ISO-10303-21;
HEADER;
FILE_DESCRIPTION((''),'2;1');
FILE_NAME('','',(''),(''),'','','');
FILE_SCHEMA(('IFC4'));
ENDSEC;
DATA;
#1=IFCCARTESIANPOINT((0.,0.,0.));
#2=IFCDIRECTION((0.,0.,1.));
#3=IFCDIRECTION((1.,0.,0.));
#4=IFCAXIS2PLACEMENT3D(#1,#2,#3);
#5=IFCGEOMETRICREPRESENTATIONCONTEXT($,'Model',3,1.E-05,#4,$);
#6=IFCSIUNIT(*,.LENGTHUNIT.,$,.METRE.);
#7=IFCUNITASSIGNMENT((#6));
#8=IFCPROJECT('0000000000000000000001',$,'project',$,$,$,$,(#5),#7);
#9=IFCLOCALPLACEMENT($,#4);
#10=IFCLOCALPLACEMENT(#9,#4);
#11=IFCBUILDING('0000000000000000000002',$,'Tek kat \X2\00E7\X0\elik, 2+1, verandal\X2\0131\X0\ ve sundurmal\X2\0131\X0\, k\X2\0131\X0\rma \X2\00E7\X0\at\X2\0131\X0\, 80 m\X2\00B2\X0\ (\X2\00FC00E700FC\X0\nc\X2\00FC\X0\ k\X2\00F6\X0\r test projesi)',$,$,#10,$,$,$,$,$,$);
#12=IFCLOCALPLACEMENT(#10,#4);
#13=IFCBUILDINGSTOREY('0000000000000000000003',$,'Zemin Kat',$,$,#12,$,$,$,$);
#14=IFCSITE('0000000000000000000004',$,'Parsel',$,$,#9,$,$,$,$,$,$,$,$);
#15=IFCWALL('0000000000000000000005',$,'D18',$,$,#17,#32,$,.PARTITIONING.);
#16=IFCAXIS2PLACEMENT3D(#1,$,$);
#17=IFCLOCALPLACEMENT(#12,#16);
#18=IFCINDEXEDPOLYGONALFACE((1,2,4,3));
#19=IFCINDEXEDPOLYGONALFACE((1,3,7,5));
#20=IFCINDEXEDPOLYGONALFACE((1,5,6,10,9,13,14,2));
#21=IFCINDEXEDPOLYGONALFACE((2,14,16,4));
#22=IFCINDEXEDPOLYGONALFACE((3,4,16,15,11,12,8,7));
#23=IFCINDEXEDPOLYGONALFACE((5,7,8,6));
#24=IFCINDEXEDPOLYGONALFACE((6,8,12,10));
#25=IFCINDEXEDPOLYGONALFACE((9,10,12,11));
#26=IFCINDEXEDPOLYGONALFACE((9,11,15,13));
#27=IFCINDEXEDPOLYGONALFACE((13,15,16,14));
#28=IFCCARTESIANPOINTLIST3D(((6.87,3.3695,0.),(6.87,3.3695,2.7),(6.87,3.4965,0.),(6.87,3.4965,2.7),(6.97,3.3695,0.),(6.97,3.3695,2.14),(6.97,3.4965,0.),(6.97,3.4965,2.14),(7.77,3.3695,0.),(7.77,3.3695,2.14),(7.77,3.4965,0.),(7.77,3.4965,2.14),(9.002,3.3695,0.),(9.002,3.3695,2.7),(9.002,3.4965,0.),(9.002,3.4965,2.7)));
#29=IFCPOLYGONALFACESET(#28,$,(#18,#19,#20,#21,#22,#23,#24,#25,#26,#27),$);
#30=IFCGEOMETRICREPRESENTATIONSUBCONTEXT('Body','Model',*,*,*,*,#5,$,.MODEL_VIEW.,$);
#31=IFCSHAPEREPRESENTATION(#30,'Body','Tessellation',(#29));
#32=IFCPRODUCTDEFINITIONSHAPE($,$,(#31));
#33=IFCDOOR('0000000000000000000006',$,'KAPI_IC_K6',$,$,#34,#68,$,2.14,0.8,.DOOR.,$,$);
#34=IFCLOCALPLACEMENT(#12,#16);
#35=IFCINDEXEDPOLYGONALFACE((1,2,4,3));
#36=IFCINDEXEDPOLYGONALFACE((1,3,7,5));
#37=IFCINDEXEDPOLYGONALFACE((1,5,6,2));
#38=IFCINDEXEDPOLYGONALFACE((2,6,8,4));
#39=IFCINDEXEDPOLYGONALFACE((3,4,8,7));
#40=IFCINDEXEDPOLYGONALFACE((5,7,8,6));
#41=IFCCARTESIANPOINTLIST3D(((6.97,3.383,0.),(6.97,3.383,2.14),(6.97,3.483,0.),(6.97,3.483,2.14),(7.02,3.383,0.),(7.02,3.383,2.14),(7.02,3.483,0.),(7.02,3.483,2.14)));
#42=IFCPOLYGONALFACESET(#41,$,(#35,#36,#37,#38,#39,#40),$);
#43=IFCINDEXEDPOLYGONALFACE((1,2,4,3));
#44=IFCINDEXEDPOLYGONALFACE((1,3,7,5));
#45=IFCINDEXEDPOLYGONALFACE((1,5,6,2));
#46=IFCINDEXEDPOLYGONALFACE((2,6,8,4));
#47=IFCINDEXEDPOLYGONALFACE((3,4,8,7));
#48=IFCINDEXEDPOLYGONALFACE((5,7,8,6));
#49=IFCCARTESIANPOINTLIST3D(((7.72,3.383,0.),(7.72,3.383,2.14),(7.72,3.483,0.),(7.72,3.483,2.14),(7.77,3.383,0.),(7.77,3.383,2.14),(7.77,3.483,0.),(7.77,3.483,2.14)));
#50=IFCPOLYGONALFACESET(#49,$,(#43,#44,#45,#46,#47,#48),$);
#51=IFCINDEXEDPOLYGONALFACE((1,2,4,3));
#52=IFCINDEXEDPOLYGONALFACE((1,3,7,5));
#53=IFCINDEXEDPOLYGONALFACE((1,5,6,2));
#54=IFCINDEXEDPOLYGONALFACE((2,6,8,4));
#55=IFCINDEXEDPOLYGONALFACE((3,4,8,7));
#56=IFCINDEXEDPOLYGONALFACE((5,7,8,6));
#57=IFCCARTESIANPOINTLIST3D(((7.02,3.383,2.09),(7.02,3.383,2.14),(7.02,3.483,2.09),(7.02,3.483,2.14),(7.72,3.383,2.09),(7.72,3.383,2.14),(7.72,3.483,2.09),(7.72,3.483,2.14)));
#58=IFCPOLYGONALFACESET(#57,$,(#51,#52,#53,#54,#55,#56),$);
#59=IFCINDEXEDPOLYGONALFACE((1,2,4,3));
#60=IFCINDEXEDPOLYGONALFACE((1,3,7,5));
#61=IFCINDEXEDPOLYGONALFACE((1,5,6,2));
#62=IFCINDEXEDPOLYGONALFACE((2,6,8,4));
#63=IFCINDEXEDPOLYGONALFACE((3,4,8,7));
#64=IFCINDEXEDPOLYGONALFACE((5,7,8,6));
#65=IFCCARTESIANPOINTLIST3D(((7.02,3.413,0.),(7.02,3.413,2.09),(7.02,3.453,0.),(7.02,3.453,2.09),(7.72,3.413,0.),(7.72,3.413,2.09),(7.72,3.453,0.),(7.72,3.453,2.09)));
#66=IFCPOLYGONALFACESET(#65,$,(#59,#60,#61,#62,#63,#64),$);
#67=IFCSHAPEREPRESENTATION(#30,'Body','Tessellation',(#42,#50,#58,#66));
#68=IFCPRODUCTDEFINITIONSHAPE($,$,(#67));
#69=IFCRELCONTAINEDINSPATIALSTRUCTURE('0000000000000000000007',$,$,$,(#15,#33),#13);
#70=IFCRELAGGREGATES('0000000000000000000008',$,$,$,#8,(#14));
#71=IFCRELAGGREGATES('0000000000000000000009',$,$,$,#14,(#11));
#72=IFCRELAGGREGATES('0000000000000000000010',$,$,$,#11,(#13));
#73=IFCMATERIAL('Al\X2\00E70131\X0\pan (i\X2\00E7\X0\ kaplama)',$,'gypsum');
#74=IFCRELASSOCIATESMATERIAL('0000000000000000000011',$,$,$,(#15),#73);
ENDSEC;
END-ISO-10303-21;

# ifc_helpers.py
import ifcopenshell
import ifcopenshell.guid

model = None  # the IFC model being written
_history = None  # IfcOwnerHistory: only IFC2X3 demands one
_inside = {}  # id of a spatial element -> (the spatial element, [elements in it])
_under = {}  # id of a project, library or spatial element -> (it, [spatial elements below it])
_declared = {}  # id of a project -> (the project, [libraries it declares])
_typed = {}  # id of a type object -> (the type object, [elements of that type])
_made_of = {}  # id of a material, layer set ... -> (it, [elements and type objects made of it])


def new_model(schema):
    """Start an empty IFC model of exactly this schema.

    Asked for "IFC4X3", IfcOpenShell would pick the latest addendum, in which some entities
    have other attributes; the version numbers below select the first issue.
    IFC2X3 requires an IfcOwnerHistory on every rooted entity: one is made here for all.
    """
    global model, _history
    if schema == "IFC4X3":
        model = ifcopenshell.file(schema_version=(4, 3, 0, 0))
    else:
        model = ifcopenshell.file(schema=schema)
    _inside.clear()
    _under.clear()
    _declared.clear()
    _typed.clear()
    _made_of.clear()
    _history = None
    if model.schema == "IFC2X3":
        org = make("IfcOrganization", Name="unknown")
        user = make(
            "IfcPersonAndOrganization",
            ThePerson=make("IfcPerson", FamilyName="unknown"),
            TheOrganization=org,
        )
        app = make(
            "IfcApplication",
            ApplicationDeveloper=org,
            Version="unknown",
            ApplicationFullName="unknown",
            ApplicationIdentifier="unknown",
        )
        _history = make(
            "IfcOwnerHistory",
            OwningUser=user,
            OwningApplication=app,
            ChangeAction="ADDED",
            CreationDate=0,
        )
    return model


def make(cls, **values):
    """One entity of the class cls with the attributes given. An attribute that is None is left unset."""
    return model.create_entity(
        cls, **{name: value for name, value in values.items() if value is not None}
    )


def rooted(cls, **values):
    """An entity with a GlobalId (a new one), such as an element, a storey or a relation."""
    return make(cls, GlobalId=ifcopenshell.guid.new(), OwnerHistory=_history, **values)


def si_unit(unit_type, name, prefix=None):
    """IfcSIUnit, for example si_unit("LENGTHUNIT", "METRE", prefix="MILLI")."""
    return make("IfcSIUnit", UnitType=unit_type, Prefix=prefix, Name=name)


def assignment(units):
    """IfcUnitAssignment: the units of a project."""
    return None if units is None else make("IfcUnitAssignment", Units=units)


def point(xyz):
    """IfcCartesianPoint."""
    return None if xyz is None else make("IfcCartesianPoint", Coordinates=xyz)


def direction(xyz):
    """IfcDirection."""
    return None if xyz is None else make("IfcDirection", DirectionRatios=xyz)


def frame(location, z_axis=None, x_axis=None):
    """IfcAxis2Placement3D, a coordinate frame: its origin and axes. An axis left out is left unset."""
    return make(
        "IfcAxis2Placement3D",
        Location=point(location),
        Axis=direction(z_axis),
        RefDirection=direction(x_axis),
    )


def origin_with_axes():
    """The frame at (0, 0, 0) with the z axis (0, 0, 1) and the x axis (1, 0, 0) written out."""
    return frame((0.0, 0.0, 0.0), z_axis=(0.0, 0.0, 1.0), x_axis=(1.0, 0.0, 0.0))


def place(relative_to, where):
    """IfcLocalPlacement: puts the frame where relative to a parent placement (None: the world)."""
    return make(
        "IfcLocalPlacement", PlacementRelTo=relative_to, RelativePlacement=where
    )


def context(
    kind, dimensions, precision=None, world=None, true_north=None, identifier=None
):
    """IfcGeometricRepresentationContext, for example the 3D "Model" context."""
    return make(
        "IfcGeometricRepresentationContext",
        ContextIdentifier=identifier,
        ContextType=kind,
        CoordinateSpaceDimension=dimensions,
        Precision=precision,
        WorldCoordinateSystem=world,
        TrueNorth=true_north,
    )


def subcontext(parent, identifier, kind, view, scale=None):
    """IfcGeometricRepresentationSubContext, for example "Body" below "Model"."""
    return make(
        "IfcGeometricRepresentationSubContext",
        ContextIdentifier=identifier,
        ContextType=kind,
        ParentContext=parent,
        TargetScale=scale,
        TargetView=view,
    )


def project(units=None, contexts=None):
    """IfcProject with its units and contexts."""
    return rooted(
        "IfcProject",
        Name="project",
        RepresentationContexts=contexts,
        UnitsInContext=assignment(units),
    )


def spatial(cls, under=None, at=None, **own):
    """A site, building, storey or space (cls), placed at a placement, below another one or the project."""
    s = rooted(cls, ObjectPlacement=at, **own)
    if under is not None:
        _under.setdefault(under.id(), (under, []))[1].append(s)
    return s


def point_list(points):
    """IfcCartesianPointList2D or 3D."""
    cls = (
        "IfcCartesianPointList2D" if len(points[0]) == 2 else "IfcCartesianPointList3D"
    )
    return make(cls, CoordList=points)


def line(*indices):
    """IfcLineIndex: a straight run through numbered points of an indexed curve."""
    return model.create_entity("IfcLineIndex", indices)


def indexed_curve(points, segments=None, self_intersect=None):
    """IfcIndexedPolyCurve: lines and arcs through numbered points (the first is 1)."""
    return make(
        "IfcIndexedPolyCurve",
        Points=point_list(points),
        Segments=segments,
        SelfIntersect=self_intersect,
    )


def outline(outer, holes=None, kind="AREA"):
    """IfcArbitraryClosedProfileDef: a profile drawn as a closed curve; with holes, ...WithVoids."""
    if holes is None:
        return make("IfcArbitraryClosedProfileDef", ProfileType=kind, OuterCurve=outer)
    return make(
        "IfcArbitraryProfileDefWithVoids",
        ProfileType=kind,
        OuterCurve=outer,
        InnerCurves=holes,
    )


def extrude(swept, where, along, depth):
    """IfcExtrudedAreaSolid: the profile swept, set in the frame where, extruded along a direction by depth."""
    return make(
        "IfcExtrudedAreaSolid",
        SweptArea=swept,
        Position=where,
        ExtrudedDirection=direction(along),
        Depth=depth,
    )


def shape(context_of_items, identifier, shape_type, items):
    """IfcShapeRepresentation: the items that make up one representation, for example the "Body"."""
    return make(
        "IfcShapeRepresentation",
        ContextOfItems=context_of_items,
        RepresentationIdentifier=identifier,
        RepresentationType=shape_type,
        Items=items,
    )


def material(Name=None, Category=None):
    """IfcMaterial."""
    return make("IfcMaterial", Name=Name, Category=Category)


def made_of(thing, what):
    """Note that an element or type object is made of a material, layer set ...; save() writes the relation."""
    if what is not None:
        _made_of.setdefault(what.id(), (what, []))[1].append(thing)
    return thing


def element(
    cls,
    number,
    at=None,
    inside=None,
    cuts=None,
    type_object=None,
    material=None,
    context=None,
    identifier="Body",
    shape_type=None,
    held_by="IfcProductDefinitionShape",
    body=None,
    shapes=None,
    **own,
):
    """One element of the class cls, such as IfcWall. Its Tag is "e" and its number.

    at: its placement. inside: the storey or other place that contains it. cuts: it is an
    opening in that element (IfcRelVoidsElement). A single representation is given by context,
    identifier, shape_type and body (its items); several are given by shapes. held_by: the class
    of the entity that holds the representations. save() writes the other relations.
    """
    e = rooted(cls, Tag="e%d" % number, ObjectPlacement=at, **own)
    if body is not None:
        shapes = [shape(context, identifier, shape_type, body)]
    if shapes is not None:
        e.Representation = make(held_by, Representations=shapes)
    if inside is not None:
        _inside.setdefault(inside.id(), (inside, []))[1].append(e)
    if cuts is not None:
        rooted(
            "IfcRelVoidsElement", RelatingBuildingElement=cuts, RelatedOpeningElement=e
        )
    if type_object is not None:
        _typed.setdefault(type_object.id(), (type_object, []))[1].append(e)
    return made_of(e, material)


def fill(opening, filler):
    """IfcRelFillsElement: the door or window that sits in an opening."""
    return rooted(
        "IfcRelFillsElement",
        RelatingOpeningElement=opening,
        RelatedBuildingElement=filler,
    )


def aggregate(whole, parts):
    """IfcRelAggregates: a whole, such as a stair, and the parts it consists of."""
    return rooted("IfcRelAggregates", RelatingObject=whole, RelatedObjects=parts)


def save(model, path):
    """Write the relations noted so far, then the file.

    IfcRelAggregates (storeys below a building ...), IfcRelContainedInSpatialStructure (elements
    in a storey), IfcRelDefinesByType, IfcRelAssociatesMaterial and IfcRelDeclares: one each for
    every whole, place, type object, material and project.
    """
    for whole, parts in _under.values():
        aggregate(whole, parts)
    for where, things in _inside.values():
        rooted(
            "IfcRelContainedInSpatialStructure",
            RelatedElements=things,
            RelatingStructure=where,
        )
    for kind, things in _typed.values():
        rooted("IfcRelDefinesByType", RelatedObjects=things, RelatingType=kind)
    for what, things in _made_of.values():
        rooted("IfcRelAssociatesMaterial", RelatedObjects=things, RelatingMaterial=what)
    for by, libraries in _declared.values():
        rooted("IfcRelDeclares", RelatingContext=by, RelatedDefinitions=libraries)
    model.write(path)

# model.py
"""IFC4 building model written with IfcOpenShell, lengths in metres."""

from ifc_helpers import new_model, si_unit, frame, origin_with_axes, place, context, subcontext, project, spatial, line, indexed_curve, outline, extrude, material, element, fill, save


model = new_model("IFC4")

# Units and contexts
model_context = context("Model", 3, precision=1e-05, world=origin_with_axes())
body_context = subcontext(model_context, "Body", "Model", "MODEL_VIEW")
ifc_project = project(units=[si_unit("LENGTHUNIT", "METRE")], contexts=[model_context])

# Site, building, storey
site_placement = place(None, origin_with_axes())
site = spatial("IfcSite", under=ifc_project, at=site_placement, Name="Parsel")
building_placement = place(site_placement, origin_with_axes())
building = spatial("IfcBuilding", under=site, at=building_placement, Name="Tek kat çelik, 2+1, verandalı ve sundurmalı, kırma çatı, 80 m² (üçüncü kör test projesi)")
storey_placement = place(building_placement, origin_with_axes())
storey = spatial("IfcBuildingStorey", under=building, at=storey_placement, Name="Zemin Kat")

# Shared definitions
ifc_material_1 = material(Name="Alçıpan (iç kaplama)", Category="gypsum")

# Wall, opening, door
wall_1_placement = place(storey_placement, origin_with_axes())
wall_1 = element("IfcWall", 1, at=wall_1_placement, inside=storey, material=ifc_material_1, Name="D18", PredefinedType="PARTITIONING", context=body_context, shape_type="SweptSolid", body=[
    extrude(outline(indexed_curve([(0.0, 0.0), (2.132, 0.0), (2.132, 0.127), (0.0, 0.127)], segments=[line(1, 2, 3, 4, 1)])), frame((6.87, 3.3695, 0.0), z_axis=(0.0, 0.0, 1.0), x_axis=(1.0, 0.0, 0.0)), (0.0, 0.0, 1.0), 2.7),
])
opening_1_placement = place(wall_1_placement, origin_with_axes())
opening_1 = element("IfcOpeningElement", 2, at=opening_1_placement, cuts=wall_1, PredefinedType="OPENING", context=body_context, shape_type="SweptSolid", body=[
    extrude(outline(indexed_curve([(0.0, 0.0), (0.8, 0.0), (0.8, 0.167), (0.0, 0.167)], segments=[line(1, 2, 3, 4, 1)])), frame((6.97, 3.3495, 0.0), z_axis=(0.0, 0.0, 1.0), x_axis=(1.0, 0.0, 0.0)), (0.0, 0.0, 1.0), 2.14),
])
door_1_placement = place(storey_placement, origin_with_axes())
door_1 = element("IfcDoor", 3, at=door_1_placement, inside=storey, Name="KAPI_IC_K6", OverallHeight=2.14, OverallWidth=0.8, PredefinedType="DOOR", context=body_context, shape_type="SweptSolid", body=[
    extrude(outline(indexed_curve([(0.0, 0.0), (0.05, 0.0), (0.05, 0.1), (0.0, 0.1)], segments=[line(1, 2, 3, 4, 1)])), frame((6.97, 3.383, 0.0), z_axis=(0.0, 0.0, 1.0), x_axis=(1.0, 0.0, 0.0)), (0.0, 0.0, 1.0), 2.14),
    extrude(outline(indexed_curve([(0.0, 0.0), (0.05, 0.0), (0.05, 0.1), (0.0, 0.1)], segments=[line(1, 2, 3, 4, 1)])), frame((7.72, 3.383, 0.0), z_axis=(0.0, 0.0, 1.0), x_axis=(1.0, 0.0, 0.0)), (0.0, 0.0, 1.0), 2.14),
    extrude(outline(indexed_curve([(0.0, 0.0), (0.7, 0.0), (0.7, 0.1), (0.0, 0.1)], segments=[line(1, 2, 3, 4, 1)])), frame((7.02, 3.383, 2.09), z_axis=(0.0, 0.0, 1.0), x_axis=(1.0, 0.0, 0.0)), (0.0, 0.0, 1.0), 0.05),
    extrude(outline(indexed_curve([(0.0, 0.0), (0.7, 0.0), (0.7, 0.04), (0.0, 0.04)], segments=[line(1, 2, 3, 4, 1)])), frame((7.02, 3.413, 0.0), z_axis=(0.0, 0.0, 1.0), x_axis=(1.0, 0.0, 0.0)), (0.0, 0.0, 1.0), 2.09),
])
fill(opening_1, door_1)

save(model, "model.ifc")
